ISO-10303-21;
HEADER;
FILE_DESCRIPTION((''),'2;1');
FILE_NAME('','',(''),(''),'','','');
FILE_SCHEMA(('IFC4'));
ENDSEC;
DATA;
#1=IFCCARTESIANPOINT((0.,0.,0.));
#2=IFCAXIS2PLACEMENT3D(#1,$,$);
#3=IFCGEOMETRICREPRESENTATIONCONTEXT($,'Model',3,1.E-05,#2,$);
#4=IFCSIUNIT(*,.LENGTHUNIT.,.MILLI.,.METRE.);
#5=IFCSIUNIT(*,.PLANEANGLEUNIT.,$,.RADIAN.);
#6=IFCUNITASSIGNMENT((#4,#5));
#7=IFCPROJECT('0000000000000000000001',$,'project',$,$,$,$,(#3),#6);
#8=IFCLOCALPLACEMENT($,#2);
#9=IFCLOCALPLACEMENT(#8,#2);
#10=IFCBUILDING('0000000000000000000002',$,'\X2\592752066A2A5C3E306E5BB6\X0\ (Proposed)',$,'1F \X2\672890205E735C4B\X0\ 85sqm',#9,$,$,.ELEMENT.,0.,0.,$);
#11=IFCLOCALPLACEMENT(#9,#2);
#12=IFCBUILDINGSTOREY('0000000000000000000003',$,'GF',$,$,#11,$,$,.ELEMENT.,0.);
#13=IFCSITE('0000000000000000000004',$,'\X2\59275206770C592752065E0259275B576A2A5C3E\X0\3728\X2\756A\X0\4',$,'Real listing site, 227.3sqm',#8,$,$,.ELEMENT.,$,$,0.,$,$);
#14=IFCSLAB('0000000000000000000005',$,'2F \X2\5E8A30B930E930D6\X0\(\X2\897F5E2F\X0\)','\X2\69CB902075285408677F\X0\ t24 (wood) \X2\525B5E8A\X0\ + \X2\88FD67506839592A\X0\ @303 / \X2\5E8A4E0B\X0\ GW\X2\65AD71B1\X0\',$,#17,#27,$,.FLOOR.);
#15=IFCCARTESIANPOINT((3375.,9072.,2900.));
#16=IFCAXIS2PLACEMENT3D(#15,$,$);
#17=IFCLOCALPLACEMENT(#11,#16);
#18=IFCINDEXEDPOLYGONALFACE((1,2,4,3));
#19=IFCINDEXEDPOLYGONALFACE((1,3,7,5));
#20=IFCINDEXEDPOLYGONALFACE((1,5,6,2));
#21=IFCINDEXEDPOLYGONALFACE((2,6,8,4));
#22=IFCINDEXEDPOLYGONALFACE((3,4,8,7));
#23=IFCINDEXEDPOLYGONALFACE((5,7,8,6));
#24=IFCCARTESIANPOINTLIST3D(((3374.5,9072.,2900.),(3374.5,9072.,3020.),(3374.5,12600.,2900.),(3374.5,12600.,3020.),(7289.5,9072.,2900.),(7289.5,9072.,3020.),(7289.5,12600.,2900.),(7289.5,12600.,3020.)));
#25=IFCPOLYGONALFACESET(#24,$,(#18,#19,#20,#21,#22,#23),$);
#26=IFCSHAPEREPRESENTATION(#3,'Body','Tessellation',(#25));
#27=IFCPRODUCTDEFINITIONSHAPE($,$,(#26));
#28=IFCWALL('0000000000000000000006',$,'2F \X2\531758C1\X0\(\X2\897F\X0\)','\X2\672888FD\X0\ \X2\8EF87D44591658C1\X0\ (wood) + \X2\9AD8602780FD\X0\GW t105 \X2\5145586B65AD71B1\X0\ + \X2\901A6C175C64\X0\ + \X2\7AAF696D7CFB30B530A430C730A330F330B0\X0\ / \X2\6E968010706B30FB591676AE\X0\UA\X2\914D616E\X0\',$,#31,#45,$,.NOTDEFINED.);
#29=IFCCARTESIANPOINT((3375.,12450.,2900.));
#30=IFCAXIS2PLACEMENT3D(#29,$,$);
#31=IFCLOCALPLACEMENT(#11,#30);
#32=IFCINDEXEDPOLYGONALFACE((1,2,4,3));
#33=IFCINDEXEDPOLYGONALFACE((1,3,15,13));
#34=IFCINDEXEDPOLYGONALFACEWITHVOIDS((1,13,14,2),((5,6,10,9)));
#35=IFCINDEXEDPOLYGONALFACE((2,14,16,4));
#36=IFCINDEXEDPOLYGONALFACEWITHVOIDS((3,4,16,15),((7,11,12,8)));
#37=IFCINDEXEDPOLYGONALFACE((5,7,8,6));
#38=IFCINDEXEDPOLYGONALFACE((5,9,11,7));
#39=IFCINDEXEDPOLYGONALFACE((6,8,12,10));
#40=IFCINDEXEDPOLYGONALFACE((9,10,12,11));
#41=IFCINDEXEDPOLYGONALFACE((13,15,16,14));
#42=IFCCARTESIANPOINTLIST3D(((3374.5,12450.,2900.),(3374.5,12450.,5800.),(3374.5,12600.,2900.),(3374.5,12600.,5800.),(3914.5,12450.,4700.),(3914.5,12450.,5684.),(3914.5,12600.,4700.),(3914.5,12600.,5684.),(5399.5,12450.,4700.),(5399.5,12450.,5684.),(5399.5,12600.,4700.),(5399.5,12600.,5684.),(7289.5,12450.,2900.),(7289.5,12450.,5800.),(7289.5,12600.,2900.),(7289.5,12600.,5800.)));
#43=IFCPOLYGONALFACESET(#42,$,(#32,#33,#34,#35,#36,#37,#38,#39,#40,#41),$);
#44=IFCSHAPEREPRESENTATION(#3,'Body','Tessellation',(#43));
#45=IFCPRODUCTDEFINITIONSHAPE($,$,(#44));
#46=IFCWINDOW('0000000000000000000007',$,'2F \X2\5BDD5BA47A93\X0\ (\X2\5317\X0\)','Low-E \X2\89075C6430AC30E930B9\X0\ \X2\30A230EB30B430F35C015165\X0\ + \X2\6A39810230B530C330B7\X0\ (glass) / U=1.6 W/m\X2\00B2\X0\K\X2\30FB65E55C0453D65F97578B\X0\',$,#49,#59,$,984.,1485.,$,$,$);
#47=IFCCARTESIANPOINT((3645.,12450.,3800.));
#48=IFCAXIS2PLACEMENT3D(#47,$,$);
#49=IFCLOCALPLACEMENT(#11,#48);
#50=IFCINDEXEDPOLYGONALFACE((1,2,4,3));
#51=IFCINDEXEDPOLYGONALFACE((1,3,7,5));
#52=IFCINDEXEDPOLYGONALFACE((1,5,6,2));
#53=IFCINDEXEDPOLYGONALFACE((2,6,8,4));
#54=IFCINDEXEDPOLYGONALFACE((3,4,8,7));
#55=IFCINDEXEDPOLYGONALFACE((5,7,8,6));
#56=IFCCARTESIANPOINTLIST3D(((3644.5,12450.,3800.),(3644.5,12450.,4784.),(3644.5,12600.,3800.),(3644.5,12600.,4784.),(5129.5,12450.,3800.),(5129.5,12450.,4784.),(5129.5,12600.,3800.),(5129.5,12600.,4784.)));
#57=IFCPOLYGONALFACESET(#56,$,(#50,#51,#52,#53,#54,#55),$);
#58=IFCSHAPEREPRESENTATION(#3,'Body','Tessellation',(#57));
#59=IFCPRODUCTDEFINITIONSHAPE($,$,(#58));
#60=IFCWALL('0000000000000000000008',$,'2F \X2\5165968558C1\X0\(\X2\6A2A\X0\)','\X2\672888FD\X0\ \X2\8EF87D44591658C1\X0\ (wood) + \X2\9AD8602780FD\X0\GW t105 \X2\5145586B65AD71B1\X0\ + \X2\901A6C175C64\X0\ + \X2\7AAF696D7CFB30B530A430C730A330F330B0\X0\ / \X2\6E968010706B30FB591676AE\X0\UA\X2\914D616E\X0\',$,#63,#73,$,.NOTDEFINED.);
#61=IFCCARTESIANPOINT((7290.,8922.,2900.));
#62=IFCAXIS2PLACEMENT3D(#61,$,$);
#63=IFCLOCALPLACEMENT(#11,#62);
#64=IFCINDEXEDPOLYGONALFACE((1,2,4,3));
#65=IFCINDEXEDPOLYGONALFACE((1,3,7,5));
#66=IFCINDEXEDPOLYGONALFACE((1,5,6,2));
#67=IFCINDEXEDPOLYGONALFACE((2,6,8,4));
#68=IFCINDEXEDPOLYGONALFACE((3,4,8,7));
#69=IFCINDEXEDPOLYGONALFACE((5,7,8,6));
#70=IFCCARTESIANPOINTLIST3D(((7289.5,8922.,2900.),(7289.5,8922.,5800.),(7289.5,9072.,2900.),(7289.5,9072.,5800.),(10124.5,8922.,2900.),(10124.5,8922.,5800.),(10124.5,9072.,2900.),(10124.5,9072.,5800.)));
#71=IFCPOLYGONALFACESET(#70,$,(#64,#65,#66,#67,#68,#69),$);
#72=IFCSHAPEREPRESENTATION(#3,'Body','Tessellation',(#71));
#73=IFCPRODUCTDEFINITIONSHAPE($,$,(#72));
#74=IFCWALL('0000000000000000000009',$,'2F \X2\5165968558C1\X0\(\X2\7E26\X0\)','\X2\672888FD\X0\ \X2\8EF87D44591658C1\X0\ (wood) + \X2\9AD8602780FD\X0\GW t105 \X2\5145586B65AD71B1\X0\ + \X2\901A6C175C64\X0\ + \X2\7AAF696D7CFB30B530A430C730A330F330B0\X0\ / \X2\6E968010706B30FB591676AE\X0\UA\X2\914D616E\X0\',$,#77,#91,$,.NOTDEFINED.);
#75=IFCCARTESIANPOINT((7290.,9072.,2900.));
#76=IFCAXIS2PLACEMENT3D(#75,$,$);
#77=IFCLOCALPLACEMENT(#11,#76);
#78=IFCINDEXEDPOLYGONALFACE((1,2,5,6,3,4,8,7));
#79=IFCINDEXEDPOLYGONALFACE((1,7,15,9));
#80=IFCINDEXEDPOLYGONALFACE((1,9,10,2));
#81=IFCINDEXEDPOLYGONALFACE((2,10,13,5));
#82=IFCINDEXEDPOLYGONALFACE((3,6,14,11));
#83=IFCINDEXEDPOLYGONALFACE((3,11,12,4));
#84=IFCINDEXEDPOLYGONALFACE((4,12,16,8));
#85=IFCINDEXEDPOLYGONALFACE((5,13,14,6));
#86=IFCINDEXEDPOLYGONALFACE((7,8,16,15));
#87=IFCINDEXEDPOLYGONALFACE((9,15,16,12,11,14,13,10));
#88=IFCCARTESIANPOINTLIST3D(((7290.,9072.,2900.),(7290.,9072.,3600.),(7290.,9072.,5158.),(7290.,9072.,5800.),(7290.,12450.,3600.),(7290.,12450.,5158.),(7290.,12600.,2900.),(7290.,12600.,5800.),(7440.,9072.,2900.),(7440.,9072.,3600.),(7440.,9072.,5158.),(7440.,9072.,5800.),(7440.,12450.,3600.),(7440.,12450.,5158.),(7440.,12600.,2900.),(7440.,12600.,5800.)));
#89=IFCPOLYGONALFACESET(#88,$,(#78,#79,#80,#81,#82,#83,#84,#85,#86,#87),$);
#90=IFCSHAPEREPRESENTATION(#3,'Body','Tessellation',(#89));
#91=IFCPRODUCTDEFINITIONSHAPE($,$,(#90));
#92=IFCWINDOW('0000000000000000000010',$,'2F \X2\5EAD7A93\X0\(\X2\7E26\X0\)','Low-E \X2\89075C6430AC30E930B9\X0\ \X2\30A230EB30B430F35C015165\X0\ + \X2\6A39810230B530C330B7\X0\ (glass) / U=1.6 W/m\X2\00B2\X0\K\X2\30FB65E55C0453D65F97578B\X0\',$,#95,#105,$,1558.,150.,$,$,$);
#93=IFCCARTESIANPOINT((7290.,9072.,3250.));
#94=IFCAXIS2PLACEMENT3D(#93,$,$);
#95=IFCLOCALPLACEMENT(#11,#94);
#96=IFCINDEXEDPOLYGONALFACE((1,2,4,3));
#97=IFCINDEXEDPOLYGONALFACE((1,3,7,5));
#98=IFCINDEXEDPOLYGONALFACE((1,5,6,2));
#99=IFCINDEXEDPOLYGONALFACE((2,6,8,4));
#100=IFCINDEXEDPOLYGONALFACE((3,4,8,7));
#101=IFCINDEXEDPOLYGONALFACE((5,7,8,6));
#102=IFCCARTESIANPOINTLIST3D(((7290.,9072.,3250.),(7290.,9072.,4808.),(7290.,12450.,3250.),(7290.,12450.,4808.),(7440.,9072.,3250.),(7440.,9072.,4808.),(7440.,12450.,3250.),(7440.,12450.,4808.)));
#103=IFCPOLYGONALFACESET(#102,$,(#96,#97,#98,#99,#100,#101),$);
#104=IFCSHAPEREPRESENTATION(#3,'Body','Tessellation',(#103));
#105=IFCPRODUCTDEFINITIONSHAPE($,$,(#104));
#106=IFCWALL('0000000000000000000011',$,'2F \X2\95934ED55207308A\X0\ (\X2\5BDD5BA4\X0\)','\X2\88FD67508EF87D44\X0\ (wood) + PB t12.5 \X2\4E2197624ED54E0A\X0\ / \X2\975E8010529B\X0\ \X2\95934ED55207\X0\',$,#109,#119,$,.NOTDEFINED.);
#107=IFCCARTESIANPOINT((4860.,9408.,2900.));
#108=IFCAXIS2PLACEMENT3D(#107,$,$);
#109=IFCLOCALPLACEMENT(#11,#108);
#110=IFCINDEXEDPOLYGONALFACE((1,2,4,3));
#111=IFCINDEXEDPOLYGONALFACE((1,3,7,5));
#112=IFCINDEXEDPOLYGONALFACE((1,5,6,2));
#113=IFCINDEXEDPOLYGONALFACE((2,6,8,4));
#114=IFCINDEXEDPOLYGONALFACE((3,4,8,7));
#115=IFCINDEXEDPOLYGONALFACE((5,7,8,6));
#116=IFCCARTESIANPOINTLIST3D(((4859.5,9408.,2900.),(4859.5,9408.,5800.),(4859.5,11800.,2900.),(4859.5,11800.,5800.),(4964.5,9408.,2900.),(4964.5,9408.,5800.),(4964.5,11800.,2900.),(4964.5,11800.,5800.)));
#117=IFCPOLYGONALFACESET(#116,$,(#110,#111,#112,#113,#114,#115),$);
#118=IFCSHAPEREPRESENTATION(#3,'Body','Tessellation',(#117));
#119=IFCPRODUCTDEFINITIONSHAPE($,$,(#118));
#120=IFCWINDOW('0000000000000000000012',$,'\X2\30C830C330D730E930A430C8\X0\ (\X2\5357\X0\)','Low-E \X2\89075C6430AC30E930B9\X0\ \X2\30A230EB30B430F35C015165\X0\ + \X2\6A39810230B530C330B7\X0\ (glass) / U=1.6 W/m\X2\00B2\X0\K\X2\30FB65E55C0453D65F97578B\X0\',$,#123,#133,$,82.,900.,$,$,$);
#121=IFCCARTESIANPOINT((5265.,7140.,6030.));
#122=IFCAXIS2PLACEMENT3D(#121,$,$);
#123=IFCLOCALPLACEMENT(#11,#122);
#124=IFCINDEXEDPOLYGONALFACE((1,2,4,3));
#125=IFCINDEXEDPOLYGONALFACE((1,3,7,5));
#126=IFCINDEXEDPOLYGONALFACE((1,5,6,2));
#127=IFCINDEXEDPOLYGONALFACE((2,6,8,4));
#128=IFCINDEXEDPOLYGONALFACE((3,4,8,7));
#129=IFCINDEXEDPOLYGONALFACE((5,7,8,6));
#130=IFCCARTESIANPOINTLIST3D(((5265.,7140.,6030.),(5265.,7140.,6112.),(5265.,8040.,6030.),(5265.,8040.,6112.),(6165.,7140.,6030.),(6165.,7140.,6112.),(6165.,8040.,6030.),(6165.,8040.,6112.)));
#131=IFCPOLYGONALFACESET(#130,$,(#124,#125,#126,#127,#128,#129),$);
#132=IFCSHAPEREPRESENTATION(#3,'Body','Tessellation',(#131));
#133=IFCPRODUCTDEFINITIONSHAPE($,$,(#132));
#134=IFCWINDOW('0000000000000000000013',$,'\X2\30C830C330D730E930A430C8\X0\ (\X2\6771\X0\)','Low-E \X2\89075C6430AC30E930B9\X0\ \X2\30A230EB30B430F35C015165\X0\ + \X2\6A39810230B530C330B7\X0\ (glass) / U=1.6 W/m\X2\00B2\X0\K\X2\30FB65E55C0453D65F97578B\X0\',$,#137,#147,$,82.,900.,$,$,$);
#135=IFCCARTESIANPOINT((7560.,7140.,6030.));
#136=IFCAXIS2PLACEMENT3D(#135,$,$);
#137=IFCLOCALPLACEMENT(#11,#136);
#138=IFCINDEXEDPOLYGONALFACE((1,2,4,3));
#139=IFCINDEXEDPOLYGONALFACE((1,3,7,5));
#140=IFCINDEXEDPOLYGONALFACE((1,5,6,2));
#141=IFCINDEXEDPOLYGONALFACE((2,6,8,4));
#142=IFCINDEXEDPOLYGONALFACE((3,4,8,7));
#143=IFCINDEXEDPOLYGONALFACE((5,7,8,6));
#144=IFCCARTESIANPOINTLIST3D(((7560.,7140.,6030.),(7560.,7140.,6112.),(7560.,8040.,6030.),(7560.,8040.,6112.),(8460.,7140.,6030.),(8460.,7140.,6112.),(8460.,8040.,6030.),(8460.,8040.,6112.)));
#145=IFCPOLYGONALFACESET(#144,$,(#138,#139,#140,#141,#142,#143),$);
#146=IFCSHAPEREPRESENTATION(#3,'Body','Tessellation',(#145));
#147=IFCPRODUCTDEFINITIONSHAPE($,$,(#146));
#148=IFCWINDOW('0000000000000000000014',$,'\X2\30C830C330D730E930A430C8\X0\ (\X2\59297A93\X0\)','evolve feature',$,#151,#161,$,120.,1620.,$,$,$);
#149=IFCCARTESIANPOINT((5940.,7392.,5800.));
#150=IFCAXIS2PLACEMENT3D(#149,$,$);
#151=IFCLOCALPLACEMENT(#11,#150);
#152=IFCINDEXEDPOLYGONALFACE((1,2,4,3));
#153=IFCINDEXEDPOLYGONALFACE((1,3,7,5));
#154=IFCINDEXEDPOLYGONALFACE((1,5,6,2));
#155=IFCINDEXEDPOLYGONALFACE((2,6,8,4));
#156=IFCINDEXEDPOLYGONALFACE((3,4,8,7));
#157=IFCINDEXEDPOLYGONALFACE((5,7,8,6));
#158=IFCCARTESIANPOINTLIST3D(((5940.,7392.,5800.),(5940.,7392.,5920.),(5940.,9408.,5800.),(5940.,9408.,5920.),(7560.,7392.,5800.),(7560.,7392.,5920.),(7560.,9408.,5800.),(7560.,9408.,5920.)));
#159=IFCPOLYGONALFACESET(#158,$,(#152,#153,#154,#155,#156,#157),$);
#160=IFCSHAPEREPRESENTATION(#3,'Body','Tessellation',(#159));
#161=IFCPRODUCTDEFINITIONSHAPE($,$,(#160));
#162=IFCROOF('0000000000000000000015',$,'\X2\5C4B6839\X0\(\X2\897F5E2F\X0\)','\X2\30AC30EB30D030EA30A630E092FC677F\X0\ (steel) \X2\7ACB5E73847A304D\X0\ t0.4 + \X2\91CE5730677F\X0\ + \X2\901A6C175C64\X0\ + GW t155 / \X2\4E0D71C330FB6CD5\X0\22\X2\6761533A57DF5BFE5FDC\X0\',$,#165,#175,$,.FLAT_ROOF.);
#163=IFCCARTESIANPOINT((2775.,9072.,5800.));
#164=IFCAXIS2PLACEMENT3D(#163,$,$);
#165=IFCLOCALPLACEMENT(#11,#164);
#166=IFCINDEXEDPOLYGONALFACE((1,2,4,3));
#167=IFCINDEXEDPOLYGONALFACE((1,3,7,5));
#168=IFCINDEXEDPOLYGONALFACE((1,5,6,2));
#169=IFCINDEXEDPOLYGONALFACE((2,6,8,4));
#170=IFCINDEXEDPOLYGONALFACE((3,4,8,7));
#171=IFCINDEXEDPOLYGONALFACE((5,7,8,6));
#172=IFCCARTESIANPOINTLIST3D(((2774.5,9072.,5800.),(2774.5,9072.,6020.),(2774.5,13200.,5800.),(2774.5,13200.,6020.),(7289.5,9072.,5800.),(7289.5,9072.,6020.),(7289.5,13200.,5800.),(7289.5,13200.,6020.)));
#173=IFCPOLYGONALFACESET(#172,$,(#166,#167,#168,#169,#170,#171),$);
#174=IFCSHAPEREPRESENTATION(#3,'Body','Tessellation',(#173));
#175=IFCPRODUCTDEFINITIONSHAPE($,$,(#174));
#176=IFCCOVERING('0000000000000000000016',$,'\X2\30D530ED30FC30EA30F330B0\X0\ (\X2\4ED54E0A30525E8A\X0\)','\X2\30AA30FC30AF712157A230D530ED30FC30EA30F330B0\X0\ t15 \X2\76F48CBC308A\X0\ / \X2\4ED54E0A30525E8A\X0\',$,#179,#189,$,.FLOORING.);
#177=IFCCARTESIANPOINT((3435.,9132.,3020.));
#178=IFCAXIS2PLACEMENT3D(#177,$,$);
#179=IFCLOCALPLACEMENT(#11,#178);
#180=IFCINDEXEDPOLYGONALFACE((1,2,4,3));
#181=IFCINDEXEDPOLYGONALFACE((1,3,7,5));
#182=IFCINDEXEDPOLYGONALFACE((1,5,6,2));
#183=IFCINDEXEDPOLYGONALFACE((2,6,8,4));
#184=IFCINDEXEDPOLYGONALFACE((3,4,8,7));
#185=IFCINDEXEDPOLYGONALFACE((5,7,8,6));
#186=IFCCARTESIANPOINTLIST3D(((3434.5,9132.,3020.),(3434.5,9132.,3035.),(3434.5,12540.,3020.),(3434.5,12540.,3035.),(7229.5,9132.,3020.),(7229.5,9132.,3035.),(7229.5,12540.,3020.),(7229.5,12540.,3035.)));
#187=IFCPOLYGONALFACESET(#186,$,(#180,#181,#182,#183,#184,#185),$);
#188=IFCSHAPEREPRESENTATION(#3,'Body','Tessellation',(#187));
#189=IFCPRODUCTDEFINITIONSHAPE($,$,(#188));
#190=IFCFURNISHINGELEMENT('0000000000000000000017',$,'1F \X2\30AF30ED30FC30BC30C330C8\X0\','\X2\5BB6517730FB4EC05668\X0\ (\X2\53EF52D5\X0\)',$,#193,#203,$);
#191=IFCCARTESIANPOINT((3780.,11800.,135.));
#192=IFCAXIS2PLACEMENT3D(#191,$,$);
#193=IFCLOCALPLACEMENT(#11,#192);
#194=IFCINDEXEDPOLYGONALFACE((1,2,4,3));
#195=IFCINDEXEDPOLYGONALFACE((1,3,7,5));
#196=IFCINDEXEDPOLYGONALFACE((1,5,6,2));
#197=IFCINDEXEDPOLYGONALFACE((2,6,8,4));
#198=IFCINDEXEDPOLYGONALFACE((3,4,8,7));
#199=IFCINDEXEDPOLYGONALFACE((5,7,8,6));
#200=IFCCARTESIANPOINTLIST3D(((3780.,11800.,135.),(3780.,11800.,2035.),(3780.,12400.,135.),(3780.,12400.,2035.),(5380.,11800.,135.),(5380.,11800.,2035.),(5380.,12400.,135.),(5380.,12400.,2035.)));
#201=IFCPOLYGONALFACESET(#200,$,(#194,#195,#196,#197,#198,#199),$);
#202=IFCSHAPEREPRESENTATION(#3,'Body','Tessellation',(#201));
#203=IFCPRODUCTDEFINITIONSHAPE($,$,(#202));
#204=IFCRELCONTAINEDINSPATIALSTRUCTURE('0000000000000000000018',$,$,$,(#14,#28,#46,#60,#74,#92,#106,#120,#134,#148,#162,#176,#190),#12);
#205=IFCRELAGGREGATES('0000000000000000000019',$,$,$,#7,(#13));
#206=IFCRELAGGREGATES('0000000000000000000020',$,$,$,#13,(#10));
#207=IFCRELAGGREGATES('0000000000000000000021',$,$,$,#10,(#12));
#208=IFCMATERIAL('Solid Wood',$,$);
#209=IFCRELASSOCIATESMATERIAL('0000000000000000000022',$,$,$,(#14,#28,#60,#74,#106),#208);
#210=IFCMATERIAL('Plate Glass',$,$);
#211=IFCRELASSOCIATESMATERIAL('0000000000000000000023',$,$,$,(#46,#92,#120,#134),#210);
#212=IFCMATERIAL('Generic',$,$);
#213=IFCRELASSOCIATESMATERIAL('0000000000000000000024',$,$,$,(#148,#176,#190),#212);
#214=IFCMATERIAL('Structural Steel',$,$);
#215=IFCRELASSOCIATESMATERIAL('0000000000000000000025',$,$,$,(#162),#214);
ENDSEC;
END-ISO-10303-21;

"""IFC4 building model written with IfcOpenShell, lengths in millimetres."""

from ifc_helpers import new_model, si_unit, frame, frame_2d, origin, place, context, project, spatial, rectangle, extrude, material, element, fill, save


model = new_model("IFC4")

# Units and contexts
model_context = context("Model", 3, precision=1e-05, world=origin())
ifc_project = project(units=[si_unit("LENGTHUNIT", "METRE", prefix="MILLI"), si_unit("PLANEANGLEUNIT", "RADIAN")], contexts=[model_context])

# Site, building, storey
site_placement = place(None, origin())
site = spatial("IfcSite", under=ifc_project, at=site_placement, Name="大分県大分市大字横尾3728番4", ObjectType="Real listing site, 227.3sqm", CompositionType="ELEMENT", RefElevation=0.0)
building_placement = place(site_placement, origin())
building = spatial("IfcBuilding", under=site, at=building_placement, Name="大分横尾の家 (Proposed)", ObjectType="1F 木造平屋 85sqm", CompositionType="ELEMENT", ElevationOfRefHeight=0.0, ElevationOfTerrain=0.0)
storey_placement = place(building_placement, origin())
storey = spatial("IfcBuildingStorey", under=building, at=storey_placement, Name="GF", CompositionType="ELEMENT", Elevation=0.0)

# Slab
ifc_material_1 = material(Name="Solid Wood")
slab_placement = place(storey_placement, frame((3375.0, 9072.0, 2900.0)))
element("IfcSlab", 1, at=slab_placement, inside=storey, material=ifc_material_1, Name="2F 床スラブ(西帯)", Description="構造用合板 t24 (wood) 剛床 + 製材根太 @303 / 床下 GW断熱", PredefinedType="FLOOR", context=model_context, shape_type="SweptSolid", body=[
    extrude(rectangle(XDim=3915.0, YDim=3528.0, at=frame_2d((1957.0, 1764.0))), frame((3375.0, 9072.0, 2900.0)), (0.0, 0.0, 1.0), 120.0),
])

# Wall, opening, window
wall_1_placement = place(storey_placement, frame((3375.0, 12450.0, 2900.0)))
wall_1 = element("IfcWall", 2, at=wall_1_placement, inside=storey, material=ifc_material_1, Name="2F 北壁(西)", Description="木製 軸組外壁 (wood) + 高性能GW t105 充填断熱 + 通気層 + 窯業系サイディング / 準耐火・外皮UA配慮", PredefinedType="NOTDEFINED", context=model_context, shape_type="SweptSolid", body=[
    extrude(rectangle(XDim=3915.0, YDim=150.0, at=frame_2d((1957.0, 75.0))), frame((3375.0, 12450.0, 2900.0)), (0.0, 0.0, 1.0), 2900.0),
])
opening_1_placement = place(storey_placement, frame((3645.0, 12450.0, 3800.0)))
opening_1 = element("IfcOpeningElement", 3, at=opening_1_placement, cuts=wall_1, PredefinedType="NOTDEFINED", context=model_context, shape_type="SweptSolid", body=[
    extrude(rectangle(XDim=1485.0, YDim=150.0, at=frame_2d((742.0, 75.0))), frame((3645.0, 12450.0, 3800.0)), (0.0, 0.0, 1.0), 984.0),
])
ifc_material_2 = material(Name="Plate Glass")
window_1_placement = place(storey_placement, frame((3645.0, 12450.0, 3800.0)))
window_1 = element("IfcWindow", 4, at=window_1_placement, inside=storey, material=ifc_material_2, Name="2F 寝室窓 (北)", Description="Low-E 複層ガラス アルゴン封入 + 樹脂サッシ (glass) / U=1.6 W/m²K・日射取得型", OverallHeight=984.0, OverallWidth=1485.0, context=model_context, shape_type="SweptSolid", body=[
    extrude(rectangle(XDim=1485.0, YDim=150.0, at=frame_2d((742.0, 75.0))), frame((3645.0, 12450.0, 3800.0)), (0.0, 0.0, 1.0), 984.0),
])
fill(opening_1, window_1)

# Wall
wall_2_placement = place(storey_placement, frame((7290.0, 8922.0, 2900.0)))
element("IfcWall", 5, at=wall_2_placement, inside=storey, material=ifc_material_1, Name="2F 入隅壁(横)", Description="木製 軸組外壁 (wood) + 高性能GW t105 充填断熱 + 通気層 + 窯業系サイディング / 準耐火・外皮UA配慮", PredefinedType="NOTDEFINED", context=model_context, shape_type="SweptSolid", body=[
    extrude(rectangle(XDim=2835.0, YDim=150.0, at=frame_2d((1417.0, 75.0))), frame((7290.0, 8922.0, 2900.0)), (0.0, 0.0, 1.0), 2900.0),
])

# Wall, opening, window
wall_3_placement = place(storey_placement, frame((7290.0, 9072.0, 2900.0)))
wall_3 = element("IfcWall", 6, at=wall_3_placement, inside=storey, material=ifc_material_1, Name="2F 入隅壁(縦)", Description="木製 軸組外壁 (wood) + 高性能GW t105 充填断熱 + 通気層 + 窯業系サイディング / 準耐火・外皮UA配慮", PredefinedType="NOTDEFINED", context=model_context, shape_type="SweptSolid", body=[
    extrude(rectangle(XDim=150.0, YDim=3528.0, at=frame_2d((75.0, 1764.0))), frame((7290.0, 9072.0, 2900.0)), (0.0, 0.0, 1.0), 2900.0),
])
opening_2_placement = place(storey_placement, frame((7290.0, 9072.0, 3250.0)))
opening_2 = element("IfcOpeningElement", 7, at=opening_2_placement, cuts=wall_3, PredefinedType="NOTDEFINED", context=model_context, shape_type="SweptSolid", body=[
    extrude(rectangle(XDim=150.0, YDim=3378.0, at=frame_2d((75.0, 1689.0))), frame((7290.0, 9072.0, 3250.0)), (0.0, 0.0, 1.0), 1558.0),
])
window_2_placement = place(storey_placement, frame((7290.0, 9072.0, 3250.0)))
window_2 = element("IfcWindow", 8, at=window_2_placement, inside=storey, material=ifc_material_2, Name="2F 庭窓(縦)", Description="Low-E 複層ガラス アルゴン封入 + 樹脂サッシ (glass) / U=1.6 W/m²K・日射取得型", OverallHeight=1558.0, OverallWidth=150.0, context=model_context, shape_type="SweptSolid", body=[
    extrude(rectangle(XDim=150.0, YDim=3378.0, at=frame_2d((75.0, 1689.0))), frame((7290.0, 9072.0, 3250.0)), (0.0, 0.0, 1.0), 1558.0),
])
fill(opening_2, window_2)

# Wall
wall_4_placement = place(storey_placement, frame((4860.0, 9408.0, 2900.0)))
element("IfcWall", 9, at=wall_4_placement, inside=storey, material=ifc_material_1, Name="2F 間仕切り (寝室)", Description="製材軸組 (wood) + PB t12.5 両面仕上 / 非耐力 間仕切", PredefinedType="NOTDEFINED", context=model_context, shape_type="SweptSolid", body=[
    extrude(rectangle(XDim=105.0, YDim=2392.0, at=frame_2d((52.0, 1196.0))), frame((4860.0, 9408.0, 2900.0)), (0.0, 0.0, 1.0), 2900.0),
])

# Windows
window_3_placement = place(storey_placement, frame((5265.0, 7140.0, 6030.0)))
element("IfcWindow", 10, at=window_3_placement, inside=storey, material=ifc_material_2, Name="トップライト (南)", Description="Low-E 複層ガラス アルゴン封入 + 樹脂サッシ (glass) / U=1.6 W/m²K・日射取得型", OverallHeight=82.0, OverallWidth=900.0, context=model_context, shape_type="SweptSolid", body=[
    extrude(rectangle(XDim=900.0, YDim=900.0, at=frame_2d((450.0, 450.0))), frame((5265.0, 7140.0, 6030.0)), (0.0, 0.0, 1.0), 82.0),
])
window_4_placement = place(storey_placement, frame((7560.0, 7140.0, 6030.0)))
element("IfcWindow", 11, at=window_4_placement, inside=storey, material=ifc_material_2, Name="トップライト (東)", Description="Low-E 複層ガラス アルゴン封入 + 樹脂サッシ (glass) / U=1.6 W/m²K・日射取得型", OverallHeight=82.0, OverallWidth=900.0, context=model_context, shape_type="SweptSolid", body=[
    extrude(rectangle(XDim=900.0, YDim=900.0, at=frame_2d((450.0, 450.0))), frame((7560.0, 7140.0, 6030.0)), (0.0, 0.0, 1.0), 82.0),
])
ifc_material_3 = material(Name="Generic")
window_5_placement = place(storey_placement, frame((5940.0, 7392.0, 5800.0)))
element("IfcWindow", 12, at=window_5_placement, inside=storey, material=ifc_material_3, Name="トップライト (天窓)", Description="evolve feature", OverallHeight=120.0, OverallWidth=1620.0, context=model_context, shape_type="SweptSolid", body=[
    extrude(rectangle(XDim=1620.0, YDim=2016.0, at=frame_2d((810.0, 1008.0))), frame((5940.0, 7392.0, 5800.0)), (0.0, 0.0, 1.0), 120.0),
])

# Roof
ifc_material_4 = material(Name="Structural Steel")
for number, where, name in (
    (13, (2775.0, 9072.0, 5800.0), "屋根(西帯)"),
):
    element("IfcRoof", number, at=place(storey_placement, frame(where)), inside=storey, material=ifc_material_4, Name=name, Description="ガルバリウム鋼板 (steel) 立平葺き t0.4 + 野地板 + 通気層 + GW t155 / 不燃・法22条区域対応", PredefinedType="FLAT_ROOF", context=model_context, shape_type="SweptSolid", body=[
        extrude(rectangle(XDim=4515.0, YDim=4128.0, at=frame_2d((2257.0, 2064.0))), frame((2775.0, 9072.0, 5800.0)), (0.0, 0.0, 1.0), 220.0),
    ])

# Covering
covering_placement = place(storey_placement, frame((3435.0, 9132.0, 3020.0)))
element("IfcCovering", 14, at=covering_placement, inside=storey, material=ifc_material_3, Name="フローリング (仕上げ床)", Description="オーク無垢フローリング t15 直貼り / 仕上げ床", PredefinedType="FLOORING", context=model_context, shape_type="SweptSolid", body=[
    extrude(rectangle(XDim=3795.0, YDim=3408.0, at=frame_2d((1897.0, 1704.0))), frame((3435.0, 9132.0, 3020.0)), (0.0, 0.0, 1.0), 15.0),
])

# Furnishing element
furnishing_1_placement = place(storey_placement, frame((3780.0, 11800.0, 135.0)))
element("IfcFurnishingElement", 15, at=furnishing_1_placement, inside=storey, material=ifc_material_3, Name="1F クローゼット", Description="家具・什器 (可動)", context=model_context, shape_type="SweptSolid", body=[
    extrude(rectangle(XDim=1600.0, YDim=600.0, at=frame_2d((800.0, 300.0))), frame((3780.0, 11800.0, 135.0)), (0.0, 0.0, 1.0), 1900.0),
])

save(model, "model.ifc")
